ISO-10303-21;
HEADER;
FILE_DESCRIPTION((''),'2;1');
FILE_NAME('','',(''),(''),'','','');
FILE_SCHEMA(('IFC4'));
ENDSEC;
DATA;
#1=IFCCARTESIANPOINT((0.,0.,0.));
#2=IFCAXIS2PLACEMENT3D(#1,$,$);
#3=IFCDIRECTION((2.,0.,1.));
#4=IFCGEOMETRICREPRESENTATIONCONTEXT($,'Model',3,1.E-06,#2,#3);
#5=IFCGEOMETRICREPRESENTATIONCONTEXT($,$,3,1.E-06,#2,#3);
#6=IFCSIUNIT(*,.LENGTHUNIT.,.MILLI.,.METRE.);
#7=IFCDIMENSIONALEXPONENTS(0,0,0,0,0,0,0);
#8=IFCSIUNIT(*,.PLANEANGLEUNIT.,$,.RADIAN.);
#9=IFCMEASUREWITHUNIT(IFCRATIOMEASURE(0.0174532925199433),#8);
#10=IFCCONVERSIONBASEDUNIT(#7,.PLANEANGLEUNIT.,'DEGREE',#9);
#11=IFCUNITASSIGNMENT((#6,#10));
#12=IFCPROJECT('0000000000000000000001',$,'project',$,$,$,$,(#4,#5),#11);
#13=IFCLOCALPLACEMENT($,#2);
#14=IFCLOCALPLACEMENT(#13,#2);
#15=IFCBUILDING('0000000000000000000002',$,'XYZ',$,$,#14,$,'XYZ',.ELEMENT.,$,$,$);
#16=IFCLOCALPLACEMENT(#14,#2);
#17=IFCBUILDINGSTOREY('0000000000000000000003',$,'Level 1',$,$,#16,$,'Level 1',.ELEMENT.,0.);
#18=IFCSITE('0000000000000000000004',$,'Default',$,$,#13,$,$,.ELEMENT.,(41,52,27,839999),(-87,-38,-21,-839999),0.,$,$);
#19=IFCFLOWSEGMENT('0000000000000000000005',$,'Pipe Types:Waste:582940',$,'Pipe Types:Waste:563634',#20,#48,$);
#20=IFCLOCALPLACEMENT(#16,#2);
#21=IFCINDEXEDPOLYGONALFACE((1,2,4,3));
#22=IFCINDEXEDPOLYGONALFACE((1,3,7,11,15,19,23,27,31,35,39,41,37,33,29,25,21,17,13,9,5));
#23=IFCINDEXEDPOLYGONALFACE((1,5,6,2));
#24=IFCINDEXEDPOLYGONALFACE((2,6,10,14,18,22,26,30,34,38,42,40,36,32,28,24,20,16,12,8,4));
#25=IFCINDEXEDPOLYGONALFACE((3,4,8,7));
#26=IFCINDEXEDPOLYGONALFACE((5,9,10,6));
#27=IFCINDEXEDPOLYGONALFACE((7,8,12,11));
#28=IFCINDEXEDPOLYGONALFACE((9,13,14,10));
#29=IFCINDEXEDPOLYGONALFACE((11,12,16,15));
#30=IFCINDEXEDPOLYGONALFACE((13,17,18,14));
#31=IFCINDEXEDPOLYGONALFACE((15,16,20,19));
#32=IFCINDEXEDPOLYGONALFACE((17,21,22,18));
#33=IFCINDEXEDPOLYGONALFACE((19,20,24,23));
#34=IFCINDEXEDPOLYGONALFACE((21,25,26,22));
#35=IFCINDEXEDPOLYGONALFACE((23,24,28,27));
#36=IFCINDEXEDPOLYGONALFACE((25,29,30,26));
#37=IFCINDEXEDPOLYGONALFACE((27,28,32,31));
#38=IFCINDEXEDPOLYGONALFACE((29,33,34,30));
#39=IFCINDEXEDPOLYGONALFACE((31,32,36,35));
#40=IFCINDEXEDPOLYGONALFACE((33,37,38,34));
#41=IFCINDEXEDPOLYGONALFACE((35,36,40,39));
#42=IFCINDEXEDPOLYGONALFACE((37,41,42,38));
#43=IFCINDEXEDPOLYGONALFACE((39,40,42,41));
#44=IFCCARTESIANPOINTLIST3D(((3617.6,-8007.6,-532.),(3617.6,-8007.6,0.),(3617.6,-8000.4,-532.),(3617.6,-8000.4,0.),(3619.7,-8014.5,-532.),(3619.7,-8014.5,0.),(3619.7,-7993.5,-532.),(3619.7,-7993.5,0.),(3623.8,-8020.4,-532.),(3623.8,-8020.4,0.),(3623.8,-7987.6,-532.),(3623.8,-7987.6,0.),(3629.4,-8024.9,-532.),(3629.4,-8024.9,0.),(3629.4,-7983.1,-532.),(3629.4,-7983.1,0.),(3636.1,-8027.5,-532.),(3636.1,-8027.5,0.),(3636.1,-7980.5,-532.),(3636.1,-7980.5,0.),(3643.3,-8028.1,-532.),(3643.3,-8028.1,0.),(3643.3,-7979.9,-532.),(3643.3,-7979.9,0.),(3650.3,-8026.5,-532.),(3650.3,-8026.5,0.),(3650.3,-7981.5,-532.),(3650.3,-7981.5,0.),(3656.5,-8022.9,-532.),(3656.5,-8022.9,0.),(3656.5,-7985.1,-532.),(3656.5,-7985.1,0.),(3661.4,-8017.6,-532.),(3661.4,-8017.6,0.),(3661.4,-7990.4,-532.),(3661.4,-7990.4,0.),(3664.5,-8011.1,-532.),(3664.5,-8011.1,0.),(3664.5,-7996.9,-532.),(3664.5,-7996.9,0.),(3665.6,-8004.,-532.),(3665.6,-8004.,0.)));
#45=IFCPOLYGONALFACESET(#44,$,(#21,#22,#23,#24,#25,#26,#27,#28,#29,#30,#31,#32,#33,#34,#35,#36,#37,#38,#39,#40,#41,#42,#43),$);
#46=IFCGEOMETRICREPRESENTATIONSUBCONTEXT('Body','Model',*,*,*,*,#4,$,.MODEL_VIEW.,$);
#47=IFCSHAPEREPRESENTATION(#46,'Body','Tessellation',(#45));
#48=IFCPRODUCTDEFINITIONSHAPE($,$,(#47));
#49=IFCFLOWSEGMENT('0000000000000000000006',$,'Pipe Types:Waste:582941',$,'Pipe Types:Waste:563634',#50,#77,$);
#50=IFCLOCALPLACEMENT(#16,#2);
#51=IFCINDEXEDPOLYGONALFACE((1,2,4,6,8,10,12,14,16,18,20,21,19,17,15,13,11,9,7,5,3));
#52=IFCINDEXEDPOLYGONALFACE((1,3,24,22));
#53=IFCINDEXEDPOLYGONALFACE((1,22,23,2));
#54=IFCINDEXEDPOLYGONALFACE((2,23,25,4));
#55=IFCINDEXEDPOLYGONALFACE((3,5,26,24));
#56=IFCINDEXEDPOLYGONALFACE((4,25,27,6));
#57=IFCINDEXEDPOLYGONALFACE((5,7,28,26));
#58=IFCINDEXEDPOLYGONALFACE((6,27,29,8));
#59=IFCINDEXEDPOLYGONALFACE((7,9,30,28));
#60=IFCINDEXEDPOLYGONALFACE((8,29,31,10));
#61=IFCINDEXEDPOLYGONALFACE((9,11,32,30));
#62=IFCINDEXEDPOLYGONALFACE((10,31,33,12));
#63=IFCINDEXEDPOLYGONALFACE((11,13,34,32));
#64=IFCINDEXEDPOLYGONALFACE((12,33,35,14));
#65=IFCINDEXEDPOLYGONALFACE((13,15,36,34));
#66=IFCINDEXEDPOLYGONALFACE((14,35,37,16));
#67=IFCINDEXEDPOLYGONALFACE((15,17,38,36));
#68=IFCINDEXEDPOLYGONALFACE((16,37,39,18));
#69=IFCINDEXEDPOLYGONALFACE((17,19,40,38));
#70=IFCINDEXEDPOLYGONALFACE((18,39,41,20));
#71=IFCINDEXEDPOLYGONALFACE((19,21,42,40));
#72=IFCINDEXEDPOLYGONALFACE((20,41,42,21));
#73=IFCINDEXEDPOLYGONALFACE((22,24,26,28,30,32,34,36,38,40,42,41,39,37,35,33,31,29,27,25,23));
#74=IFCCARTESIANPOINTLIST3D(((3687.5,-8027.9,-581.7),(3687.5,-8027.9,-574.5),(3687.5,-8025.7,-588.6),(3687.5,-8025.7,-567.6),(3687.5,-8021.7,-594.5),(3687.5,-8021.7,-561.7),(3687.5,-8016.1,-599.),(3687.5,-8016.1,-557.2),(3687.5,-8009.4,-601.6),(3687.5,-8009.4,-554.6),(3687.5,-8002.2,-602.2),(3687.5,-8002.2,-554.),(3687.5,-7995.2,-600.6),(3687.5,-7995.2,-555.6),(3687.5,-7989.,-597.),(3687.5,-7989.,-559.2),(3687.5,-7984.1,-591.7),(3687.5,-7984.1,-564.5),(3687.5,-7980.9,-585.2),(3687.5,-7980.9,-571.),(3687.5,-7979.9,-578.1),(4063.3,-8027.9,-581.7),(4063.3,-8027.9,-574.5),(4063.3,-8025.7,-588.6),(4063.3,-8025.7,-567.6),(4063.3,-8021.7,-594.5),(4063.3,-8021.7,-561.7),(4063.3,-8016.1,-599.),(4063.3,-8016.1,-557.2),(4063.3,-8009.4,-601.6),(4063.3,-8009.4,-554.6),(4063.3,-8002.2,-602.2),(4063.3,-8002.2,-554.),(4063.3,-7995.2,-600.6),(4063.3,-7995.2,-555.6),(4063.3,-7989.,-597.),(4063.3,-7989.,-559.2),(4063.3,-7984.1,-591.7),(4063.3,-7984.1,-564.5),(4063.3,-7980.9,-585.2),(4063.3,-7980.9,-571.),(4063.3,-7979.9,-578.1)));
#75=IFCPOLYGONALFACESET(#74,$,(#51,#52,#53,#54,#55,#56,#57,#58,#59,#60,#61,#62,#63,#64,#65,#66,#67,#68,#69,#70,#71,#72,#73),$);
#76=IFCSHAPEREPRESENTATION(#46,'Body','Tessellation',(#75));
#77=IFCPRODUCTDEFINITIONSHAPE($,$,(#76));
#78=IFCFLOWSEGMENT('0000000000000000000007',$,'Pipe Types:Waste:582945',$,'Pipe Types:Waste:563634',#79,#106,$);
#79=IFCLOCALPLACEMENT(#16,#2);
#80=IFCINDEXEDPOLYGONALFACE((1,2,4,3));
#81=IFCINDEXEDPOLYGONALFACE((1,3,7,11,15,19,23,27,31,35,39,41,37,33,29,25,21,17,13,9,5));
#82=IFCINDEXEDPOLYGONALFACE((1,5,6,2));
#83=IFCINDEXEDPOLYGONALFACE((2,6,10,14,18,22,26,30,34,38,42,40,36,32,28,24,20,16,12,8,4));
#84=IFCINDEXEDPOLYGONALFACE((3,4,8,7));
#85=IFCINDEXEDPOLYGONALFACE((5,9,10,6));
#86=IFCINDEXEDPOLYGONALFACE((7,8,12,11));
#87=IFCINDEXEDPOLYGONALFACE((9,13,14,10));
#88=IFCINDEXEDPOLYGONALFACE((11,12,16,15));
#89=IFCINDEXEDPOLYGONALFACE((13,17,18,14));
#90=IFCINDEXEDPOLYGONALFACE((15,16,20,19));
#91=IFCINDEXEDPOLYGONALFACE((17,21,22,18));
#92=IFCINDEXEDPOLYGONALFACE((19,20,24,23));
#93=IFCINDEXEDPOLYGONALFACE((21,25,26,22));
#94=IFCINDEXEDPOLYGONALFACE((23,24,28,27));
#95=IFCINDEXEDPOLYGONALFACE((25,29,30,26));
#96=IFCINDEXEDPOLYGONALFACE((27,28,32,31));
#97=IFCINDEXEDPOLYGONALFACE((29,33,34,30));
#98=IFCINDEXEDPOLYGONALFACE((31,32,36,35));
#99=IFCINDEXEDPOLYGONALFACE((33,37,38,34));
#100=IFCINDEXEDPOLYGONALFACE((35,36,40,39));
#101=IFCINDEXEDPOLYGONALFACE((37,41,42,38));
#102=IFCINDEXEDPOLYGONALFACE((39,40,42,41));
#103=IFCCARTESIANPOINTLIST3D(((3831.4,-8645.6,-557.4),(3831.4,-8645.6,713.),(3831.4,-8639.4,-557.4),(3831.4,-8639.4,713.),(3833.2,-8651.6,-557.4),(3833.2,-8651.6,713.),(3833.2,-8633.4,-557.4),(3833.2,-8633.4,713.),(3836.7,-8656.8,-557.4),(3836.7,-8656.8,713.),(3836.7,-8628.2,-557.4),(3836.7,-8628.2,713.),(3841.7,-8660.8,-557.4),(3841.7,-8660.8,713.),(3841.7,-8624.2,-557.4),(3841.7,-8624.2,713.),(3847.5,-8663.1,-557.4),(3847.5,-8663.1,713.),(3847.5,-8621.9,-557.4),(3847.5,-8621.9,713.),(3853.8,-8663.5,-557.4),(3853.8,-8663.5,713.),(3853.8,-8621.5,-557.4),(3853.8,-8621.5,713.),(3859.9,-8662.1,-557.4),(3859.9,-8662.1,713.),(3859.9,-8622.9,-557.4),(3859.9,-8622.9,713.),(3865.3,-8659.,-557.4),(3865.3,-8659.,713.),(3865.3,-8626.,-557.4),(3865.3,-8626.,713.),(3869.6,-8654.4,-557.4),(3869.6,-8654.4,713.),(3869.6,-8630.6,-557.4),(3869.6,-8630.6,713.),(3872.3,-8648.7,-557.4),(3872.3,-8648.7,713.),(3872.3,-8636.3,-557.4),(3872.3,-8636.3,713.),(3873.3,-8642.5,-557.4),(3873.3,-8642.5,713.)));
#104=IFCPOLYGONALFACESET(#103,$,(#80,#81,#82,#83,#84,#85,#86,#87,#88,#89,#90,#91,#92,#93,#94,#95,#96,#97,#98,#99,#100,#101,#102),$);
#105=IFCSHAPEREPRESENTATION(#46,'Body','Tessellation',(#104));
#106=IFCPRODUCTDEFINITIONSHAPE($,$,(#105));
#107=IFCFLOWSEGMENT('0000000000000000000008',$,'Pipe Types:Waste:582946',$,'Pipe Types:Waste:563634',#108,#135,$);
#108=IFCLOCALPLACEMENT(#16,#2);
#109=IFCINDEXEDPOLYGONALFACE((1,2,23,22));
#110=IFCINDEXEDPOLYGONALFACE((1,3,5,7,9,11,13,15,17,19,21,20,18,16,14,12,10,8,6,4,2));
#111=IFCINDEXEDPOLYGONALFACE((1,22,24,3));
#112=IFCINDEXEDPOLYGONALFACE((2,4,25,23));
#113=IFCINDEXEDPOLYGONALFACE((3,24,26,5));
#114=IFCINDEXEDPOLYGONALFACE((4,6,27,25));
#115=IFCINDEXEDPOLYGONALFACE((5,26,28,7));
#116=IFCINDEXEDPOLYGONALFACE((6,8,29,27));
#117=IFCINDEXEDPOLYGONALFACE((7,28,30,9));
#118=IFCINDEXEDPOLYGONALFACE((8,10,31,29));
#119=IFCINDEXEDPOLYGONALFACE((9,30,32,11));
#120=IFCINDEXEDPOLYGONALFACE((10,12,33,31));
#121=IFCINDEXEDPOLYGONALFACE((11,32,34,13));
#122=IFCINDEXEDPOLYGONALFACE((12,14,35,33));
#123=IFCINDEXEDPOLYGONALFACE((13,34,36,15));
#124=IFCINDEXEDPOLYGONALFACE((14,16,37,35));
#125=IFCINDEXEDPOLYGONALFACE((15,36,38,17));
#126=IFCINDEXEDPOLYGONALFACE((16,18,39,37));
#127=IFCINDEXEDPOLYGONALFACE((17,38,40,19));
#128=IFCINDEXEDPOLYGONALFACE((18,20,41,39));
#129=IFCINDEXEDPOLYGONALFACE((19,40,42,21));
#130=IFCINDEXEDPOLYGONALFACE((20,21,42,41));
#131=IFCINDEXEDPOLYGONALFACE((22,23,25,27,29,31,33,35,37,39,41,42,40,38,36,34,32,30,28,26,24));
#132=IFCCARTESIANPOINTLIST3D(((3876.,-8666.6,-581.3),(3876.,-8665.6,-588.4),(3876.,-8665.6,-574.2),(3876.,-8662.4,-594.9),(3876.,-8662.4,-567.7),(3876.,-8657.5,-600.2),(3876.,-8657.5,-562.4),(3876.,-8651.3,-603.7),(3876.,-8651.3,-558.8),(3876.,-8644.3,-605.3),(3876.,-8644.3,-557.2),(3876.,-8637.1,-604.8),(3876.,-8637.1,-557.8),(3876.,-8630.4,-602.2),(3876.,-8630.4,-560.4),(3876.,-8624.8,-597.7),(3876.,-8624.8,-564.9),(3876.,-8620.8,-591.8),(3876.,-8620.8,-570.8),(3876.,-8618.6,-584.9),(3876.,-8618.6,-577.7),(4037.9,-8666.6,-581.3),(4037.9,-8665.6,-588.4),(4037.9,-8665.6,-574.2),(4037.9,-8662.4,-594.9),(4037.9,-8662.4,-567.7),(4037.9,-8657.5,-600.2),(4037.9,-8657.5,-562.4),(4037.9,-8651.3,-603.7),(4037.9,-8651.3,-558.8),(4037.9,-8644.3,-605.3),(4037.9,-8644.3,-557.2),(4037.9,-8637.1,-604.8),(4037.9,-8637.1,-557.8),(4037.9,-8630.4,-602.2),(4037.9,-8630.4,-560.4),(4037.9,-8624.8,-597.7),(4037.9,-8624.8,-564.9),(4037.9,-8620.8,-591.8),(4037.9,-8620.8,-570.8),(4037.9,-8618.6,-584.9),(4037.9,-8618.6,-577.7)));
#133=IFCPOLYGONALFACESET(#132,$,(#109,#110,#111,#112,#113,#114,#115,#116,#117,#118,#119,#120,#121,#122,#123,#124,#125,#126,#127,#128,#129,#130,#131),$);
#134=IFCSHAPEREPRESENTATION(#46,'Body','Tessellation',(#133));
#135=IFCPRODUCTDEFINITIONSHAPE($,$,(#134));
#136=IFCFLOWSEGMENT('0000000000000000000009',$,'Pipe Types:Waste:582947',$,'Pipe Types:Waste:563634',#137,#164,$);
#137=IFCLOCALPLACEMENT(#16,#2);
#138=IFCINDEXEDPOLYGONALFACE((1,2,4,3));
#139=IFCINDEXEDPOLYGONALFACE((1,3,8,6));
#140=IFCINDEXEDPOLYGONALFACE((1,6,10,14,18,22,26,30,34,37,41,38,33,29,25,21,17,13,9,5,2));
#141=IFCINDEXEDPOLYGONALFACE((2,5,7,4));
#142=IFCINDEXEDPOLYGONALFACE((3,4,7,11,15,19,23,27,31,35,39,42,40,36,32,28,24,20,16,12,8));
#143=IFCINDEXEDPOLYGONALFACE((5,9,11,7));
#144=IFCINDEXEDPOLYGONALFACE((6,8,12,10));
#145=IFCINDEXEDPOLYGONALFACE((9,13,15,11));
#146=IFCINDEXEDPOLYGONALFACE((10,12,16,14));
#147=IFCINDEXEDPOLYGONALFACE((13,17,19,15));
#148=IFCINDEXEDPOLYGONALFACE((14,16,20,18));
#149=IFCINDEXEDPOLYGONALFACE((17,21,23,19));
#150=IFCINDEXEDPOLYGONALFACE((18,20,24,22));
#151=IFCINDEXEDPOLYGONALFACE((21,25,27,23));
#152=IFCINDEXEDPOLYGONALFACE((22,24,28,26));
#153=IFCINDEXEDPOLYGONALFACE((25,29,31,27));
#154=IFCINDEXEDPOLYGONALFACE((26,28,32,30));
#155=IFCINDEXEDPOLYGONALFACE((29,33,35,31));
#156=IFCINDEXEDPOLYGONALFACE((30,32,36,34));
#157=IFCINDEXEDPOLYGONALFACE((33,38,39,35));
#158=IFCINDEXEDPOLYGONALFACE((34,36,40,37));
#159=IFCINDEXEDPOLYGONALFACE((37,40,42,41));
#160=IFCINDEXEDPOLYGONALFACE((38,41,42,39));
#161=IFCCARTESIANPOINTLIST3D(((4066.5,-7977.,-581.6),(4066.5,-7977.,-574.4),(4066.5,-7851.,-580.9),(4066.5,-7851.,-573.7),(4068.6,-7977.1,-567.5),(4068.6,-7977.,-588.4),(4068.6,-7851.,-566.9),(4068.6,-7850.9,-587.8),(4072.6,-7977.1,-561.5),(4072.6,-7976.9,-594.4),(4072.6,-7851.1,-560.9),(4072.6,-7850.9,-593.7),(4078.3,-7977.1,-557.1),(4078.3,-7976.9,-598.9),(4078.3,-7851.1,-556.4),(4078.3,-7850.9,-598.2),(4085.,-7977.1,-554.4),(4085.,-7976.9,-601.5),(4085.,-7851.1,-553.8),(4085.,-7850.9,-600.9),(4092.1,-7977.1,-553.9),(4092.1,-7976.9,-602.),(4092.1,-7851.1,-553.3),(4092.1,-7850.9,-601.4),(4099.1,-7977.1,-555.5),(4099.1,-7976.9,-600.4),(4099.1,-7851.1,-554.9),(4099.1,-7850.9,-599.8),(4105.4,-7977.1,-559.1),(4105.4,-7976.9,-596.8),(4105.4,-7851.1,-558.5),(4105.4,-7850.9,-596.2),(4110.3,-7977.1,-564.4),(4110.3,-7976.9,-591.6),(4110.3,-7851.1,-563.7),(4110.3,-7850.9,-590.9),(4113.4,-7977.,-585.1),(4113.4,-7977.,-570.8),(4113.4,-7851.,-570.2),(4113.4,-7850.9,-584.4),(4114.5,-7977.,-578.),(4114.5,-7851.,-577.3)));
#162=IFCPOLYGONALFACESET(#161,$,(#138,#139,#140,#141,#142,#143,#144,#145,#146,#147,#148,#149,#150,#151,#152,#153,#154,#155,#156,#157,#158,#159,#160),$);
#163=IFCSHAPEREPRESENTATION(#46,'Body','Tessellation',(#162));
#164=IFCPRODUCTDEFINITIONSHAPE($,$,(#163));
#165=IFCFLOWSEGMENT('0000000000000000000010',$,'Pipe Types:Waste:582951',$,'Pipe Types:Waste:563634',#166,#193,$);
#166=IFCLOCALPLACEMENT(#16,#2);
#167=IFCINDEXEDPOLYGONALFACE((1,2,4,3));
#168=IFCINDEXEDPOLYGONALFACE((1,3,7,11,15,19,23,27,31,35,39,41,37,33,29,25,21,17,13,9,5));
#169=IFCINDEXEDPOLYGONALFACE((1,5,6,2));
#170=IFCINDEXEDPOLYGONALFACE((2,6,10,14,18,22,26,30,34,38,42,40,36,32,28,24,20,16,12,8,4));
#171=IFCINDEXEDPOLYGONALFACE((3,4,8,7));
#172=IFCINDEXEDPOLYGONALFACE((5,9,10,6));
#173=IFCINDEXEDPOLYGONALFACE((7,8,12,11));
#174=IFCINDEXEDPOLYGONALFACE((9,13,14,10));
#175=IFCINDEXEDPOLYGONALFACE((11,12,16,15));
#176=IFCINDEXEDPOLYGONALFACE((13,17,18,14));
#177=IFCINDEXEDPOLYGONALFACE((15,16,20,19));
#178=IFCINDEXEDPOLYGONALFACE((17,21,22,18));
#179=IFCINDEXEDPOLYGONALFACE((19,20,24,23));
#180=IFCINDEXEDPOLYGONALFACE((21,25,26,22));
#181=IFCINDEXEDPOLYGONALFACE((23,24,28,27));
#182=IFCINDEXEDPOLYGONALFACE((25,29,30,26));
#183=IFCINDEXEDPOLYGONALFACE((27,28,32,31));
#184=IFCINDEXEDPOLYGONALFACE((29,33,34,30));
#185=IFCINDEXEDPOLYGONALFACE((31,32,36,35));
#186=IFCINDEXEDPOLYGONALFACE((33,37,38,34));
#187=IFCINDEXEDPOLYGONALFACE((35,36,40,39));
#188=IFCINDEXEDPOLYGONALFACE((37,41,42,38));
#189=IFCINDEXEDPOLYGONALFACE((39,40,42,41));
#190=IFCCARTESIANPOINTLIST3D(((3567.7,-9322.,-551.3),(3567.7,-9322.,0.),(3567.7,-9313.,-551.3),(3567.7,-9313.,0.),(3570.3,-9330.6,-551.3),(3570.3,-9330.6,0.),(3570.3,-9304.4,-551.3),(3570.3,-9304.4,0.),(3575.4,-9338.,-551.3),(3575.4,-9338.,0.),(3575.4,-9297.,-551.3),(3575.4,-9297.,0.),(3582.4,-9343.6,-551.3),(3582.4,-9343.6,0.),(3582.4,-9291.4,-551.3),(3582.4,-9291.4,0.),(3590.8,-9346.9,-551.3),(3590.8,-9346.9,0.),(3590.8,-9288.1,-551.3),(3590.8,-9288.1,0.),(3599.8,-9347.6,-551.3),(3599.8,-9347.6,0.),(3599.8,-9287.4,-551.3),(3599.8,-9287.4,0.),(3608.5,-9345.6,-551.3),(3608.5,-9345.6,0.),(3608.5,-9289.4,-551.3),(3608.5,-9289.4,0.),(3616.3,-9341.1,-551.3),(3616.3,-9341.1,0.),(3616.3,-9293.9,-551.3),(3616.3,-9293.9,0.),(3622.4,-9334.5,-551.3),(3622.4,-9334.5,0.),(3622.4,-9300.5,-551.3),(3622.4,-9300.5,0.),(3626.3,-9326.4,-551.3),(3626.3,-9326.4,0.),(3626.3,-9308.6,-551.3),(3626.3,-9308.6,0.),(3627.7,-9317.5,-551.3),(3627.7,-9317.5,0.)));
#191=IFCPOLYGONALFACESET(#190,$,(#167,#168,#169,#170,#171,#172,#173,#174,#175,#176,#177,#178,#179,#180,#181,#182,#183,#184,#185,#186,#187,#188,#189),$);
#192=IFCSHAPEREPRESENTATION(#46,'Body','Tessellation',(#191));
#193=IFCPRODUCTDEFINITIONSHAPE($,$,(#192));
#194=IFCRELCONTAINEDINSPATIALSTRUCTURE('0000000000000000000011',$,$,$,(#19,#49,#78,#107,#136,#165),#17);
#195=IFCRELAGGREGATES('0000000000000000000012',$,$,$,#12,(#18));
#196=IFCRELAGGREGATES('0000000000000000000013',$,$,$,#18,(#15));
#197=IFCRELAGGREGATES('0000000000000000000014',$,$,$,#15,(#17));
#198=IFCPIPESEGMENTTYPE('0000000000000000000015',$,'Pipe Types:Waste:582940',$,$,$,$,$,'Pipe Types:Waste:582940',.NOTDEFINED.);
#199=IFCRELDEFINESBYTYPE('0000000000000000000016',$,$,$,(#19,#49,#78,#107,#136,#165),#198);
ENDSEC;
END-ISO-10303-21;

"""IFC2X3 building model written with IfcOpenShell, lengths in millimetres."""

from ifc_helpers import new_model, entity, si_unit, converted_unit, direction, frame, frame_2d, origin, origin_2d_with_axis, place, context, subcontext, project, spatial, circle, extrude, type_object, element, save


model = new_model("IFC2X3")

# Units and contexts
model_context = context("Model", 3, precision=1e-06, world=origin(), true_north=direction((2.0, 0.0, 1.0)))
context_of_model = context(None, 3, precision=1e-06, world=origin(), true_north=direction((2.0, 0.0, 1.0)))
body_context = subcontext(model_context, "Body", "Model", "MODEL_VIEW")
ifc_project = project(units=[si_unit("LENGTHUNIT", "METRE", prefix="MILLI"), converted_unit("PLANEANGLEUNIT", "DEGREE", entity("IfcRatioMeasure", 0.0174532925199433), si_unit("PLANEANGLEUNIT", "RADIAN"), dimensions=[0, 0, 0, 0, 0, 0, 0])], contexts=[model_context, context_of_model])

# Site, building, storey
site_placement = place(None, origin())
site = spatial("IfcSite", under=ifc_project, at=site_placement, Name="Default", CompositionType="ELEMENT", RefLatitude=(41, 52, 27, 839999), RefLongitude=(-87, -38, -21, -839999), RefElevation=0.0)
building_placement = place(site_placement, origin())
building = spatial("IfcBuilding", under=site, at=building_placement, Name="XYZ", LongName="XYZ", CompositionType="ELEMENT")
storey_placement = place(building_placement, origin())
storey = spatial("IfcBuildingStorey", under=building, at=storey_placement, Name="Level 1", LongName="Level 1", CompositionType="ELEMENT", Elevation=0.0)

# Flow segments
pipe_segment_type = type_object("IfcPipeSegmentType", Name="Pipe Types:Waste:582940", ElementType="Pipe Types:Waste:582940", PredefinedType="NOTDEFINED")
flow_segment_1_placement = place(storey_placement, origin())
element("IfcFlowSegment", 1, at=flow_segment_1_placement, inside=storey, type_object=pipe_segment_type, Name="Pipe Types:Waste:582940", ObjectType="Pipe Types:Waste:563634", context=body_context, shape_type="SweptSolid", body=[
    extrude(circle(Radius=24.1, at=frame_2d((0.0, 0.0), x_axis=(1.0, 0.0))), frame((3641.5, -8004.0, -532.0)), (0.0, 0.0, 1.0), 532.0),
])
flow_segment_2_placement = place(storey_placement, origin())
element("IfcFlowSegment", 2, at=flow_segment_2_placement, inside=storey, type_object=pipe_segment_type, Name="Pipe Types:Waste:582941", ObjectType="Pipe Types:Waste:563634", context=body_context, shape_type="SweptSolid", body=[
    extrude(circle(Radius=24.1, at=frame_2d((0.0, 0.0), x_axis=(1.0, 0.0))), frame((3687.5, -8004.0, -578.1), z_axis=(1.0, 0.0, 0.0), x_axis=(0.0, 1.0, 0.0)), (0.0, 0.0, 1.0), 375.8),
])
flow_segment_3_placement = place(storey_placement, origin())
element("IfcFlowSegment", 3, at=flow_segment_3_placement, inside=storey, type_object=pipe_segment_type, Name="Pipe Types:Waste:582945", ObjectType="Pipe Types:Waste:563634", context=body_context, shape_type="SweptSolid", body=[
    extrude(circle(Radius=21.1, at=origin_2d_with_axis()), frame((3852.2, -8642.5, -557.4)), (0.0, 0.0, 1.0), 1270.4),
])
flow_segment_4_placement = place(storey_placement, origin())
element("IfcFlowSegment", 4, at=flow_segment_4_placement, inside=storey, type_object=pipe_segment_type, Name="Pipe Types:Waste:582946", ObjectType="Pipe Types:Waste:563634", context=body_context, shape_type="SweptSolid", body=[
    extrude(circle(Radius=24.1, at=origin_2d_with_axis()), frame((3876.0, -8642.5, -581.3), z_axis=(1.0, 0.0, 0.0), x_axis=(0.0, -1.0, 0.0)), (0.0, 0.0, 1.0), 161.9),
])
flow_segment_5_placement = place(storey_placement, origin())
element("IfcFlowSegment", 5, at=flow_segment_5_placement, inside=storey, type_object=pipe_segment_type, Name="Pipe Types:Waste:582947", ObjectType="Pipe Types:Waste:563634", context=body_context, shape_type="SweptSolid", body=[
    extrude(circle(Radius=24.1, at=frame_2d((0.0, 0.0), x_axis=(1.0, 0.0))), frame((4090.3, -7977.0, -578.0), z_axis=(0.0, 0.999988, 0.005), x_axis=(1.0, 0.0, 0.0)), (0.0, 0.0, 1.0), 126.0),
])
flow_segment_6_placement = place(storey_placement, origin())
element("IfcFlowSegment", 6, at=flow_segment_6_placement, inside=storey, type_object=pipe_segment_type, Name="Pipe Types:Waste:582951", ObjectType="Pipe Types:Waste:563634", context=body_context, shape_type="SweptSolid", body=[
    extrude(circle(Radius=30.2, at=frame_2d((0.0, 0.0), x_axis=(1.0, 0.0))), frame((3597.5, -9317.5, -551.3)), (0.0, 0.0, 1.0), 551.3),
])

save(model, "model.ifc")
